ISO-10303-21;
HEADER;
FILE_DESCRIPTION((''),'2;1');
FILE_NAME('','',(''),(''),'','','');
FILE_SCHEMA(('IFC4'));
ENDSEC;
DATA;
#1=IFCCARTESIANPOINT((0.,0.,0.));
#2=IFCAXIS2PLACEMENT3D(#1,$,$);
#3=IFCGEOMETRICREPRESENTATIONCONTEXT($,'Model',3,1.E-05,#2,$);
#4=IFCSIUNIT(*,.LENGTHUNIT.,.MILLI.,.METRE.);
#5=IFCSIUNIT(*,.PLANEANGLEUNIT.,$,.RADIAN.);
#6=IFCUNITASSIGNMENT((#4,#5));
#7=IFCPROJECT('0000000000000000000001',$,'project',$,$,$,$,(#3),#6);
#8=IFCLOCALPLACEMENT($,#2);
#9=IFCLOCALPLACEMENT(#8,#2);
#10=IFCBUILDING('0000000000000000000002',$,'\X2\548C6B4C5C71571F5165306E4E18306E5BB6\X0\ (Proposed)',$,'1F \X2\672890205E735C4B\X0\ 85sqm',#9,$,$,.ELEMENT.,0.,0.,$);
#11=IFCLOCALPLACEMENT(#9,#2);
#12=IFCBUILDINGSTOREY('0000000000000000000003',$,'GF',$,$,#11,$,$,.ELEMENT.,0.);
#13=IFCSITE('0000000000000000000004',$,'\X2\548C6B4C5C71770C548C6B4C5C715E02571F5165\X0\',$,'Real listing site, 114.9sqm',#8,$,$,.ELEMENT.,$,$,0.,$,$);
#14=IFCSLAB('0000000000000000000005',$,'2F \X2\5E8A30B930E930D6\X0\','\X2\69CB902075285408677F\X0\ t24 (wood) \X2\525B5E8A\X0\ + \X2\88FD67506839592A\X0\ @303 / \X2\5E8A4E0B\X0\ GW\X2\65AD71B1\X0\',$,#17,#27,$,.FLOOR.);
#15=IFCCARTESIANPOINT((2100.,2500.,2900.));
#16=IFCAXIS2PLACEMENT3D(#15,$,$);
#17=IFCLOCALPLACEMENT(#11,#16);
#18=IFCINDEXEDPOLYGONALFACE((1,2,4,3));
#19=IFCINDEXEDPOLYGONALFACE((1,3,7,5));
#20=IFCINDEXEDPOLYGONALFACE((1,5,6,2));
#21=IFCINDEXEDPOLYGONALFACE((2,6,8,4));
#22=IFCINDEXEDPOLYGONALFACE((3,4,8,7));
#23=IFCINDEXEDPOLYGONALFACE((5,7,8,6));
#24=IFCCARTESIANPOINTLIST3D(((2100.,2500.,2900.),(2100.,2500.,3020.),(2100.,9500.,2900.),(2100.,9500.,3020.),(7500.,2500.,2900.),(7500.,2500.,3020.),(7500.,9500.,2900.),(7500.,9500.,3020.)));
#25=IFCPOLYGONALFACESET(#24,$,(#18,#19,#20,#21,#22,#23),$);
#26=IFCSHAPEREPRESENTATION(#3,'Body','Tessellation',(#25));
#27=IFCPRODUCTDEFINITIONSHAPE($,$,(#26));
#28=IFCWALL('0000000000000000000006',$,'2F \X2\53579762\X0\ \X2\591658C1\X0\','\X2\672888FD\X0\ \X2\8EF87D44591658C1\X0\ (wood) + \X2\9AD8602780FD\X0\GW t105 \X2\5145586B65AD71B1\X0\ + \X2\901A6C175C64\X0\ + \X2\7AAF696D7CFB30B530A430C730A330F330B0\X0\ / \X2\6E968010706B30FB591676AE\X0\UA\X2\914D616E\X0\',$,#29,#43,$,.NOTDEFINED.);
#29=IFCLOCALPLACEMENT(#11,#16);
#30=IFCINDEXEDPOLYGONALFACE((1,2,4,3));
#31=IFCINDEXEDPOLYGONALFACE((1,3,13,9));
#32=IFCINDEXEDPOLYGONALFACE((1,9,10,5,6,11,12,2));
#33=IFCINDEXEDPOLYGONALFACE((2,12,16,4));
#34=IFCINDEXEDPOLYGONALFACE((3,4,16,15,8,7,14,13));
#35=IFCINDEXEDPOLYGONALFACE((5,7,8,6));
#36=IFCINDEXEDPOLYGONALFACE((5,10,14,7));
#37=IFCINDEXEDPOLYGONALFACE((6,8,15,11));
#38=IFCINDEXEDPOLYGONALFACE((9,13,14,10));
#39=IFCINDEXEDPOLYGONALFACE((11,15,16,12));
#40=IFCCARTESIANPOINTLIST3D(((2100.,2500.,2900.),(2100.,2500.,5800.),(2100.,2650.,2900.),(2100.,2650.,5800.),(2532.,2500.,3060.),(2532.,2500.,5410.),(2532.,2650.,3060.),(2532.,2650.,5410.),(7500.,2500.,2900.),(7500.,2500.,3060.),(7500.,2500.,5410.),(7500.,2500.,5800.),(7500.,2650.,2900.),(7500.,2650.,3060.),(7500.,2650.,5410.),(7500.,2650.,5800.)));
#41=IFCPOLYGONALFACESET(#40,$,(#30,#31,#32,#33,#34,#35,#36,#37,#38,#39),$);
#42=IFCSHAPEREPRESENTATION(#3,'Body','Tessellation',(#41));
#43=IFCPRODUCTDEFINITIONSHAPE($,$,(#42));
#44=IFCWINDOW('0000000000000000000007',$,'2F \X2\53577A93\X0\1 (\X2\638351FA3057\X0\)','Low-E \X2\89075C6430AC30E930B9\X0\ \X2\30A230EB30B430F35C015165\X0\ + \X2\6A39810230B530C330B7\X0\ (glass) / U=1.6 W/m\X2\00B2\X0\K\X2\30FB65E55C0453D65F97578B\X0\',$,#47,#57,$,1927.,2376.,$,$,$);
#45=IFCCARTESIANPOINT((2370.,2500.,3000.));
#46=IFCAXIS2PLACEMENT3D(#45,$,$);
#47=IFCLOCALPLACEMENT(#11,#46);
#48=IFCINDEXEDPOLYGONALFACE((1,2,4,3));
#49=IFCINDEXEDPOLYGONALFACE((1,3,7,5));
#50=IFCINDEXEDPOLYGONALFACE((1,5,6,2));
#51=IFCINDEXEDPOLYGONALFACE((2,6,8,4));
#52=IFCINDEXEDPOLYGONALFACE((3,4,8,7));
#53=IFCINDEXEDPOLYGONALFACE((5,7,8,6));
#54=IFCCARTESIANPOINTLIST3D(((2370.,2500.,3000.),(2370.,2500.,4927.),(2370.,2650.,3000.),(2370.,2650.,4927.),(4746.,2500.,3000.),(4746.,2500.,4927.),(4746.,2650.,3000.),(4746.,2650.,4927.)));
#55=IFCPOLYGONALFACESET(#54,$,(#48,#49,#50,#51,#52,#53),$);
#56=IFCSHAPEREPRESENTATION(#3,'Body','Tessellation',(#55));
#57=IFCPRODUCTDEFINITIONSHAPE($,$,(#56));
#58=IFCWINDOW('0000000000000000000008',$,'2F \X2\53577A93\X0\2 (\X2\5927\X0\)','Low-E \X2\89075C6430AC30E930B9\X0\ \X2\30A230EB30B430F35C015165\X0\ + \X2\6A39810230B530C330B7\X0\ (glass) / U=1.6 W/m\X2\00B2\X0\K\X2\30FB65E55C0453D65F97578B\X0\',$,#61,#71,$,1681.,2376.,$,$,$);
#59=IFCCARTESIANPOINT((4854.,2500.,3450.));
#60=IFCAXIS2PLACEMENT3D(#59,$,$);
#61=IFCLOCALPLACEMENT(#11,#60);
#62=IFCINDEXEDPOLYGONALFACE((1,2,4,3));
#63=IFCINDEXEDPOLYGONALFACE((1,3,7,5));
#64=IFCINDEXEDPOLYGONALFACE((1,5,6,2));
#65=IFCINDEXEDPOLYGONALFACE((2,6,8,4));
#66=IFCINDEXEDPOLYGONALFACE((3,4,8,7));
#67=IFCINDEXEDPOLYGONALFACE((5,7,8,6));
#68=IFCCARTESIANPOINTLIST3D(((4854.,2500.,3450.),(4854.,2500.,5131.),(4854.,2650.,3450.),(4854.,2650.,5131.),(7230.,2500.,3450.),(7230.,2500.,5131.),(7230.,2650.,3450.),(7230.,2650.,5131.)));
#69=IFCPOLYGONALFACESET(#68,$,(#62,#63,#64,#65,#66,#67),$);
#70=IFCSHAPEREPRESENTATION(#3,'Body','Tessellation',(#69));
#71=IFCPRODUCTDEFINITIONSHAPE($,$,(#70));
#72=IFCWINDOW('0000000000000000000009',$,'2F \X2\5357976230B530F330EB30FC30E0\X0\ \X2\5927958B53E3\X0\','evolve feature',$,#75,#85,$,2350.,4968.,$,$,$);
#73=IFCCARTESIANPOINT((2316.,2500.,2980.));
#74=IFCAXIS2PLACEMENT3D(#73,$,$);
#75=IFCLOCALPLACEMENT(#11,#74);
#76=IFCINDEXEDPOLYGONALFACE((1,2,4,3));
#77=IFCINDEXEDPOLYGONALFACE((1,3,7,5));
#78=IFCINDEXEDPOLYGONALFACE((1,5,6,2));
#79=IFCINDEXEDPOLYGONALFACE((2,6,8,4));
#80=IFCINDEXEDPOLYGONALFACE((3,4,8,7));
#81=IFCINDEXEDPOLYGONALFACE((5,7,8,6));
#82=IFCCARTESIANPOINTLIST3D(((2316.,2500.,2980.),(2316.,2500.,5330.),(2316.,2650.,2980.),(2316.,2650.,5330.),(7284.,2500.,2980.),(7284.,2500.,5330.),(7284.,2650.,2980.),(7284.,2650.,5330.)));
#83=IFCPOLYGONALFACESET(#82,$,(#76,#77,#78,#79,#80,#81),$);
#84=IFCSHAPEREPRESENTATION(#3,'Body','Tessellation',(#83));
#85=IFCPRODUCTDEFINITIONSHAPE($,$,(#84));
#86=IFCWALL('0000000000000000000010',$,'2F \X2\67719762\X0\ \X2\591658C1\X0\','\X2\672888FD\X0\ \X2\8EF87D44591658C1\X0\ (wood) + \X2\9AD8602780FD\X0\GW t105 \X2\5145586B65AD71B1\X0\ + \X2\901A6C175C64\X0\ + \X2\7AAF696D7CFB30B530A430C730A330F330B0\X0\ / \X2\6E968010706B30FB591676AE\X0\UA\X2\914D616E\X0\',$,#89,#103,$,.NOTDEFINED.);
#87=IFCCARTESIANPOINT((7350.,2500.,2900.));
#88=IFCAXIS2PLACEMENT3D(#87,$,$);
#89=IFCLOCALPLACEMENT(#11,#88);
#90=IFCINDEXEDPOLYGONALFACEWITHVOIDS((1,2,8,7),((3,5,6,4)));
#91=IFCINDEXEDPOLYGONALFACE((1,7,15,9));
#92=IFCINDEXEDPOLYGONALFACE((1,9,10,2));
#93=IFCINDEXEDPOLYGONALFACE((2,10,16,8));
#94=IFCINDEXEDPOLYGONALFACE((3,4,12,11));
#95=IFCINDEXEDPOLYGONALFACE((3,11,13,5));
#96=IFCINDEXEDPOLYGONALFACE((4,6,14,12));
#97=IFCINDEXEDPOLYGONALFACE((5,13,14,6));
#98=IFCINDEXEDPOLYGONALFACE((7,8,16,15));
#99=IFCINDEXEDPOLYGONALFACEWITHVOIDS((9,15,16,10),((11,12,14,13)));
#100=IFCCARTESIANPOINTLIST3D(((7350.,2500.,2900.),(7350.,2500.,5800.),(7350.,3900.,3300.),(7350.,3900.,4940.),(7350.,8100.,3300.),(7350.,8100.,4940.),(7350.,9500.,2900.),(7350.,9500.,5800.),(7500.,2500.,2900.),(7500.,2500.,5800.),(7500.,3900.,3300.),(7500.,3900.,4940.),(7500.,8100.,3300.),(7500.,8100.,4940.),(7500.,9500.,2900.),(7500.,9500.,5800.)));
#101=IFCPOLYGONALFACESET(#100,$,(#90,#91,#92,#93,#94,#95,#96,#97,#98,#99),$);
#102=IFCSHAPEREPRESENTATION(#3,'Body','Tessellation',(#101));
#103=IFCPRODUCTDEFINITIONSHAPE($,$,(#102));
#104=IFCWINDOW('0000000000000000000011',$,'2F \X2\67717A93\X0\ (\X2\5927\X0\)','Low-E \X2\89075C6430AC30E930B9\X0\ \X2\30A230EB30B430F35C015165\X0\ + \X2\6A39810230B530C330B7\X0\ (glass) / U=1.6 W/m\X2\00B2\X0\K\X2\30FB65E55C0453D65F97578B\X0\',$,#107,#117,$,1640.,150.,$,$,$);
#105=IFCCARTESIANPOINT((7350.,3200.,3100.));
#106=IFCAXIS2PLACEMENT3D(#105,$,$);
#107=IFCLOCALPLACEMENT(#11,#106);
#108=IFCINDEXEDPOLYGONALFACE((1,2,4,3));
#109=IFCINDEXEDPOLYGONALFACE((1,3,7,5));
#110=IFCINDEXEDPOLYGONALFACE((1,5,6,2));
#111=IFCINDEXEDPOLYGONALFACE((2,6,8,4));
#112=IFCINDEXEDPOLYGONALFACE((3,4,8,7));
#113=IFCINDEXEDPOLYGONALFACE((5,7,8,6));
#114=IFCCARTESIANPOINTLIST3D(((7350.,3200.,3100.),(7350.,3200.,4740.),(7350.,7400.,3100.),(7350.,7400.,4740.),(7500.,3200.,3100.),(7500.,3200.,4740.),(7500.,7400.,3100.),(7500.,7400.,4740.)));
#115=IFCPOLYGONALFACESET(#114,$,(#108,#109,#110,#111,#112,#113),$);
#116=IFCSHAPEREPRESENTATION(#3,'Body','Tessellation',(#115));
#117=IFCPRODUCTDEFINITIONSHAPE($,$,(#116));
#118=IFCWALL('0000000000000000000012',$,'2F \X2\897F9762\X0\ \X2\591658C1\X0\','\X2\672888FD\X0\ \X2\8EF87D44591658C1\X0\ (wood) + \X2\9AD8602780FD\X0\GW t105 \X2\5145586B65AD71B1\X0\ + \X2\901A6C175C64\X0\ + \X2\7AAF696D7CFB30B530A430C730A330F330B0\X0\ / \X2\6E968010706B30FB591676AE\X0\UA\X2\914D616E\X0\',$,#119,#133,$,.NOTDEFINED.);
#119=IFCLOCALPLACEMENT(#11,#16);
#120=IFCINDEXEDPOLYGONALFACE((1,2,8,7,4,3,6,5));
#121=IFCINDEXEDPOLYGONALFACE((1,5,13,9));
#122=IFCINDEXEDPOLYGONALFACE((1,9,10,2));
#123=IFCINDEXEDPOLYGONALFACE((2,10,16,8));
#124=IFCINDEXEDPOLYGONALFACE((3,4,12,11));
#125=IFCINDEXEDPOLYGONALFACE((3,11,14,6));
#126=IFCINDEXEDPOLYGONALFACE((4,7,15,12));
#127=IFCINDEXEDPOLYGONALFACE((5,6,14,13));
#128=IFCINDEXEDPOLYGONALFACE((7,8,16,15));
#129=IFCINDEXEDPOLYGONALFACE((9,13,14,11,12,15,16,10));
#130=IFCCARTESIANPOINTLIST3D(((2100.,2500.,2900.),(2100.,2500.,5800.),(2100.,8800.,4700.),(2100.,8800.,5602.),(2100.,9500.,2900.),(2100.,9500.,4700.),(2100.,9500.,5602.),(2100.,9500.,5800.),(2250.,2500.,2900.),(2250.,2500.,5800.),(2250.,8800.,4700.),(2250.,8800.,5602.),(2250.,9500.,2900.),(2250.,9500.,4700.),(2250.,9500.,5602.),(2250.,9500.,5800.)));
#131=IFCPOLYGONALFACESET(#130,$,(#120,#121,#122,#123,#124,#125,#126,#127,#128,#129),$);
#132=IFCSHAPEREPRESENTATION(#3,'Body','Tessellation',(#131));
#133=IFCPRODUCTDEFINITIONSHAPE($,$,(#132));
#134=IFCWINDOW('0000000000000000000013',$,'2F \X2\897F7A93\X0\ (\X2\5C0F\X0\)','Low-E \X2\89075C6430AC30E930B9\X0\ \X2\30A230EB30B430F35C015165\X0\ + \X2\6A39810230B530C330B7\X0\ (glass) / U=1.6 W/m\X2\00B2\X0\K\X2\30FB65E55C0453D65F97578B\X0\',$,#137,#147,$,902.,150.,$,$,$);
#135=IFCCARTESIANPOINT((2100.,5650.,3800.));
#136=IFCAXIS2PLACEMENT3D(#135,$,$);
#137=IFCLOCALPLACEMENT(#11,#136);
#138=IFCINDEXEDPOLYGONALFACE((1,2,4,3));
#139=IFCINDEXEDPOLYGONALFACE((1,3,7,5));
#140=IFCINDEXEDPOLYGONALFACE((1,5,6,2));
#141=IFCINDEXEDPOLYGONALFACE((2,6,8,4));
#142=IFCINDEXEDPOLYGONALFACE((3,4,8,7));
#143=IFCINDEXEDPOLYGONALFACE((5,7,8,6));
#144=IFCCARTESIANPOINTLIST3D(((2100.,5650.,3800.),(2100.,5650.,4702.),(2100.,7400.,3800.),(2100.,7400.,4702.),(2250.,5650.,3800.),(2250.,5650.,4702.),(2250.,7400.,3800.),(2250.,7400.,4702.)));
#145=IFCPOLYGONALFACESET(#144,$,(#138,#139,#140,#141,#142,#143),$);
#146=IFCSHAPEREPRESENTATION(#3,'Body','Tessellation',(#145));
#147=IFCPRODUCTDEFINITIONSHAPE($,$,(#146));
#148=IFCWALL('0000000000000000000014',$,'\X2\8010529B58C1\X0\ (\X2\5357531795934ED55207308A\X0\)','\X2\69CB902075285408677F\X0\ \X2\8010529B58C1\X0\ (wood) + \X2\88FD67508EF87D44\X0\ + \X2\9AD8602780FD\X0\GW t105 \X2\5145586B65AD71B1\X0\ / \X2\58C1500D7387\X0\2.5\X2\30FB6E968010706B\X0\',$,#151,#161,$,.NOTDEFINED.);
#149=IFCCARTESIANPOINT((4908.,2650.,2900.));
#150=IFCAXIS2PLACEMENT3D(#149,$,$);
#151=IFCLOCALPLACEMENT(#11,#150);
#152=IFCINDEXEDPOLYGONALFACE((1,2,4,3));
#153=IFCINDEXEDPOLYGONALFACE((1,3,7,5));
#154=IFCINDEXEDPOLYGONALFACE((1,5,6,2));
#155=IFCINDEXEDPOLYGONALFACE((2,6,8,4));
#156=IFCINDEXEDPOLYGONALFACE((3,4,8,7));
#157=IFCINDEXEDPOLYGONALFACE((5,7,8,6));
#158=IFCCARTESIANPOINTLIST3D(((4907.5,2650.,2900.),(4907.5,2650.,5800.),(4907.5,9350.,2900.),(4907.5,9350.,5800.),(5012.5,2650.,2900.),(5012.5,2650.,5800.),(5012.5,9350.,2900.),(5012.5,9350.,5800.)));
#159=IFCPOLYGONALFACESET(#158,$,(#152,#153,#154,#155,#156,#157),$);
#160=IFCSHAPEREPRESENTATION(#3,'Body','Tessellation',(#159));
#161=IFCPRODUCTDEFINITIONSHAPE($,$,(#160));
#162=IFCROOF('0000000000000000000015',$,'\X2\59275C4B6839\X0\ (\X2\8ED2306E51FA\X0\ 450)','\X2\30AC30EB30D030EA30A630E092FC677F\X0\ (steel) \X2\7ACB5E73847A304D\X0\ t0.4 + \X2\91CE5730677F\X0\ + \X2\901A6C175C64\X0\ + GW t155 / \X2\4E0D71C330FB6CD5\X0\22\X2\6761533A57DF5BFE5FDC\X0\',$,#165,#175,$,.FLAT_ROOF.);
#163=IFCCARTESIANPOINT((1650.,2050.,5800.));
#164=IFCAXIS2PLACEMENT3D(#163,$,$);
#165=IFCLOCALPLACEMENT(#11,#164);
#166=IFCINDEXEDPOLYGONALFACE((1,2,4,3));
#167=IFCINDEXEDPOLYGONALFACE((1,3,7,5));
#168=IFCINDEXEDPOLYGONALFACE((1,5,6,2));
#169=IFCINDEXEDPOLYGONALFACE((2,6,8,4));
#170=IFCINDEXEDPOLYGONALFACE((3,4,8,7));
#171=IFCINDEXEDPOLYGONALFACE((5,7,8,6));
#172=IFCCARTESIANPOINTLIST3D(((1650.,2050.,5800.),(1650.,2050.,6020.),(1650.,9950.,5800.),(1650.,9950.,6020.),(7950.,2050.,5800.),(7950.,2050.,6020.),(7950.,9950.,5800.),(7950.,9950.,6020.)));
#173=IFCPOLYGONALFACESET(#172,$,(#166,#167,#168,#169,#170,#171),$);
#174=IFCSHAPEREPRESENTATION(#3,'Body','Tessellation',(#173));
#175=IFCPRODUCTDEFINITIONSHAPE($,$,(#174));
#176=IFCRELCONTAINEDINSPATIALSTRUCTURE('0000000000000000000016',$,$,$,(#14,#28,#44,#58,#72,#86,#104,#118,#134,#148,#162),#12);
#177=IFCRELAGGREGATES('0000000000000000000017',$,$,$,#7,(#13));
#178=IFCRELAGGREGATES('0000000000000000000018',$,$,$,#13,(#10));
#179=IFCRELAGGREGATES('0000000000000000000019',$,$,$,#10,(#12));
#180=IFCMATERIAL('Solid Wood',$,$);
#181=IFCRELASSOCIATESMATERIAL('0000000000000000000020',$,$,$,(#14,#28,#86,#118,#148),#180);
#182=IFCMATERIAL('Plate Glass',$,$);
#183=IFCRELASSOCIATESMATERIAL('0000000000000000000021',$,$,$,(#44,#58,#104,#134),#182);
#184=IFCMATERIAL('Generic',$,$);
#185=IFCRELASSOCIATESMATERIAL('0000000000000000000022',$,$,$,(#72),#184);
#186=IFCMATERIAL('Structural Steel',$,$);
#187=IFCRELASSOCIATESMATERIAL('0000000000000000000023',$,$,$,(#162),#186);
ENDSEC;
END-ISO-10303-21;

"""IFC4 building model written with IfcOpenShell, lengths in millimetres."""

from ifc_helpers import new_model, si_unit, frame, frame_2d, origin, place, context, project, spatial, rectangle, extrude, material, element, fill, save


model = new_model("IFC4")

# Units and contexts
model_context = context("Model", 3, precision=1e-05, world=origin())
ifc_project = project(units=[si_unit("LENGTHUNIT", "METRE", prefix="MILLI"), si_unit("PLANEANGLEUNIT", "RADIAN")], contexts=[model_context])

# Site, building, storey
site_placement = place(None, origin())
site = spatial("IfcSite", under=ifc_project, at=site_placement, Name="和歌山県和歌山市土入", ObjectType="Real listing site, 114.9sqm", CompositionType="ELEMENT", RefElevation=0.0)
building_placement = place(site_placement, origin())
building = spatial("IfcBuilding", under=site, at=building_placement, Name="和歌山土入の丘の家 (Proposed)", ObjectType="1F 木造平屋 85sqm", CompositionType="ELEMENT", ElevationOfRefHeight=0.0, ElevationOfTerrain=0.0)
storey_placement = place(building_placement, origin())
storey = spatial("IfcBuildingStorey", under=building, at=storey_placement, Name="GF", CompositionType="ELEMENT", Elevation=0.0)

# Slab
ifc_material_1 = material(Name="Solid Wood")
slab_placement = place(storey_placement, frame((2100.0, 2500.0, 2900.0)))
element("IfcSlab", 1, at=slab_placement, inside=storey, material=ifc_material_1, Name="2F 床スラブ", Description="構造用合板 t24 (wood) 剛床 + 製材根太 @303 / 床下 GW断熱", PredefinedType="FLOOR", context=model_context, shape_type="SweptSolid", body=[
    extrude(rectangle(XDim=5400.0, YDim=7000.0, at=frame_2d((2700.0, 3500.0))), frame((2100.0, 2500.0, 2900.0)), (0.0, 0.0, 1.0), 120.0),
])

# Wall, openings, windows
wall_1_placement = place(storey_placement, frame((2100.0, 2500.0, 2900.0)))
wall_1 = element("IfcWall", 2, at=wall_1_placement, inside=storey, material=ifc_material_1, Name="2F 南面 外壁", Description="木製 軸組外壁 (wood) + 高性能GW t105 充填断熱 + 通気層 + 窯業系サイディング / 準耐火・外皮UA配慮", PredefinedType="NOTDEFINED", context=model_context, shape_type="SweptSolid", body=[
    extrude(rectangle(XDim=5400.0, YDim=150.0, at=frame_2d((2700.0, 75.0))), frame((2100.0, 2500.0, 2900.0)), (0.0, 0.0, 1.0), 2900.0),
])
opening_1_placement = place(storey_placement, frame((2370.0, 2500.0, 3000.0)))
opening_1 = element("IfcOpeningElement", 3, at=opening_1_placement, cuts=wall_1, PredefinedType="NOTDEFINED", context=model_context, shape_type="SweptSolid", body=[
    extrude(rectangle(XDim=2376.0, YDim=150.0, at=frame_2d((1188.0, 75.0))), frame((2370.0, 2500.0, 3000.0)), (0.0, 0.0, 1.0), 1927.0),
])
opening_2_placement = place(storey_placement, frame((4854.0, 2500.0, 3450.0)))
opening_2 = element("IfcOpeningElement", 4, at=opening_2_placement, cuts=wall_1, PredefinedType="NOTDEFINED", context=model_context, shape_type="SweptSolid", body=[
    extrude(rectangle(XDim=2376.0, YDim=150.0, at=frame_2d((1188.0, 75.0))), frame((4854.0, 2500.0, 3450.0)), (0.0, 0.0, 1.0), 1681.0),
])
opening_3_placement = place(storey_placement, frame((2316.0, 2500.0, 2980.0)))
opening_3 = element("IfcOpeningElement", 5, at=opening_3_placement, cuts=wall_1, PredefinedType="NOTDEFINED", context=model_context, shape_type="SweptSolid", body=[
    extrude(rectangle(XDim=4968.0, YDim=150.0, at=frame_2d((2484.0, 75.0))), frame((2316.0, 2500.0, 2980.0)), (0.0, 0.0, 1.0), 2350.0),
])
ifc_material_2 = material(Name="Plate Glass")
window_1_placement = place(storey_placement, frame((2370.0, 2500.0, 3000.0)))
window_1 = element("IfcWindow", 6, at=window_1_placement, inside=storey, material=ifc_material_2, Name="2F 南窓1 (掃出し)", Description="Low-E 複層ガラス アルゴン封入 + 樹脂サッシ (glass) / U=1.6 W/m²K・日射取得型", OverallHeight=1927.0, OverallWidth=2376.0, context=model_context, shape_type="SweptSolid", body=[
    extrude(rectangle(XDim=2376.0, YDim=150.0, at=frame_2d((1188.0, 75.0))), frame((2370.0, 2500.0, 3000.0)), (0.0, 0.0, 1.0), 1927.0),
])
fill(opening_1, window_1)
window_2_placement = place(storey_placement, frame((4854.0, 2500.0, 3450.0)))
window_2 = element("IfcWindow", 7, at=window_2_placement, inside=storey, material=ifc_material_2, Name="2F 南窓2 (大)", Description="Low-E 複層ガラス アルゴン封入 + 樹脂サッシ (glass) / U=1.6 W/m²K・日射取得型", OverallHeight=1681.0, OverallWidth=2376.0, context=model_context, shape_type="SweptSolid", body=[
    extrude(rectangle(XDim=2376.0, YDim=150.0, at=frame_2d((1188.0, 75.0))), frame((4854.0, 2500.0, 3450.0)), (0.0, 0.0, 1.0), 1681.0),
])
fill(opening_2, window_2)
ifc_material_3 = material(Name="Generic")
window_3_placement = place(storey_placement, frame((2316.0, 2500.0, 2980.0)))
window_3 = element("IfcWindow", 8, at=window_3_placement, inside=storey, material=ifc_material_3, Name="2F 南面サンルーム 大開口", Description="evolve feature", OverallHeight=2350.0, OverallWidth=4968.0, context=model_context, shape_type="SweptSolid", body=[
    extrude(rectangle(XDim=4968.0, YDim=150.0, at=frame_2d((2484.0, 75.0))), frame((2316.0, 2500.0, 2980.0)), (0.0, 0.0, 1.0), 2350.0),
])
fill(opening_3, window_3)

# Walls, openings, windows
wall_2_placement = place(storey_placement, frame((7350.0, 2500.0, 2900.0)))
wall_2 = element("IfcWall", 9, at=wall_2_placement, inside=storey, material=ifc_material_1, Name="2F 東面 外壁", Description="木製 軸組外壁 (wood) + 高性能GW t105 充填断熱 + 通気層 + 窯業系サイディング / 準耐火・外皮UA配慮", PredefinedType="NOTDEFINED", context=model_context, shape_type="SweptSolid", body=[
    extrude(rectangle(XDim=150.0, YDim=7000.0, at=frame_2d((75.0, 3500.0))), frame((7350.0, 2500.0, 2900.0)), (0.0, 0.0, 1.0), 2900.0),
])
opening_4_placement = place(storey_placement, frame((7350.0, 3200.0, 3100.0)))
opening_4 = element("IfcOpeningElement", 10, at=opening_4_placement, cuts=wall_2, PredefinedType="NOTDEFINED", context=model_context, shape_type="SweptSolid", body=[
    extrude(rectangle(XDim=150.0, YDim=4200.0, at=frame_2d((75.0, 2100.0))), frame((7350.0, 3200.0, 3100.0)), (0.0, 0.0, 1.0), 1640.0),
])
window_4_placement = place(storey_placement, frame((7350.0, 3200.0, 3100.0)))
window_4 = element("IfcWindow", 11, at=window_4_placement, inside=storey, material=ifc_material_2, Name="2F 東窓 (大)", Description="Low-E 複層ガラス アルゴン封入 + 樹脂サッシ (glass) / U=1.6 W/m²K・日射取得型", OverallHeight=1640.0, OverallWidth=150.0, context=model_context, shape_type="SweptSolid", body=[
    extrude(rectangle(XDim=150.0, YDim=4200.0, at=frame_2d((75.0, 2100.0))), frame((7350.0, 3200.0, 3100.0)), (0.0, 0.0, 1.0), 1640.0),
])
fill(opening_4, window_4)
wall_3_placement = place(storey_placement, frame((2100.0, 2500.0, 2900.0)))
wall_3 = element("IfcWall", 12, at=wall_3_placement, inside=storey, material=ifc_material_1, Name="2F 西面 外壁", Description="木製 軸組外壁 (wood) + 高性能GW t105 充填断熱 + 通気層 + 窯業系サイディング / 準耐火・外皮UA配慮", PredefinedType="NOTDEFINED", context=model_context, shape_type="SweptSolid", body=[
    extrude(rectangle(XDim=150.0, YDim=7000.0, at=frame_2d((75.0, 3500.0))), frame((2100.0, 2500.0, 2900.0)), (0.0, 0.0, 1.0), 2900.0),
])
opening_5_placement = place(storey_placement, frame((2100.0, 5650.0, 3800.0)))
opening_5 = element("IfcOpeningElement", 13, at=opening_5_placement, cuts=wall_3, PredefinedType="NOTDEFINED", context=model_context, shape_type="SweptSolid", body=[
    extrude(rectangle(XDim=150.0, YDim=1750.0, at=frame_2d((75.0, 875.0))), frame((2100.0, 5650.0, 3800.0)), (0.0, 0.0, 1.0), 902.0),
])
window_5_placement = place(storey_placement, frame((2100.0, 5650.0, 3800.0)))
window_5 = element("IfcWindow", 14, at=window_5_placement, inside=storey, material=ifc_material_2, Name="2F 西窓 (小)", Description="Low-E 複層ガラス アルゴン封入 + 樹脂サッシ (glass) / U=1.6 W/m²K・日射取得型", OverallHeight=902.0, OverallWidth=150.0, context=model_context, shape_type="SweptSolid", body=[
    extrude(rectangle(XDim=150.0, YDim=1750.0, at=frame_2d((75.0, 875.0))), frame((2100.0, 5650.0, 3800.0)), (0.0, 0.0, 1.0), 902.0),
])
fill(opening_5, window_5)

# Wall
wall_4_placement = place(storey_placement, frame((4908.0, 2650.0, 2900.0)))
element("IfcWall", 15, at=wall_4_placement, inside=storey, material=ifc_material_1, Name="耐力壁 (南北間仕切り)", Description="構造用合板 耐力壁 (wood) + 製材軸組 + 高性能GW t105 充填断熱 / 壁倍率2.5・準耐火", PredefinedType="NOTDEFINED", context=model_context, shape_type="SweptSolid", body=[
    extrude(rectangle(XDim=105.0, YDim=6700.0, at=frame_2d((52.0, 3350.0))), frame((4908.0, 2650.0, 2900.0)), (0.0, 0.0, 1.0), 2900.0),
])

# Roof
ifc_material_4 = material(Name="Structural Steel")
roof_placement = place(storey_placement, frame((1650.0, 2050.0, 5800.0)))
element("IfcRoof", 16, at=roof_placement, inside=storey, material=ifc_material_4, Name="大屋根 (軒の出 450)", Description="ガルバリウム鋼板 (steel) 立平葺き t0.4 + 野地板 + 通気層 + GW t155 / 不燃・法22条区域対応", PredefinedType="FLAT_ROOF", context=model_context, shape_type="SweptSolid", body=[
    extrude(rectangle(XDim=6300.0, YDim=7900.0, at=frame_2d((3150.0, 3950.0))), frame((1650.0, 2050.0, 5800.0)), (0.0, 0.0, 1.0), 220.0),
])

save(model, "model.ifc")
